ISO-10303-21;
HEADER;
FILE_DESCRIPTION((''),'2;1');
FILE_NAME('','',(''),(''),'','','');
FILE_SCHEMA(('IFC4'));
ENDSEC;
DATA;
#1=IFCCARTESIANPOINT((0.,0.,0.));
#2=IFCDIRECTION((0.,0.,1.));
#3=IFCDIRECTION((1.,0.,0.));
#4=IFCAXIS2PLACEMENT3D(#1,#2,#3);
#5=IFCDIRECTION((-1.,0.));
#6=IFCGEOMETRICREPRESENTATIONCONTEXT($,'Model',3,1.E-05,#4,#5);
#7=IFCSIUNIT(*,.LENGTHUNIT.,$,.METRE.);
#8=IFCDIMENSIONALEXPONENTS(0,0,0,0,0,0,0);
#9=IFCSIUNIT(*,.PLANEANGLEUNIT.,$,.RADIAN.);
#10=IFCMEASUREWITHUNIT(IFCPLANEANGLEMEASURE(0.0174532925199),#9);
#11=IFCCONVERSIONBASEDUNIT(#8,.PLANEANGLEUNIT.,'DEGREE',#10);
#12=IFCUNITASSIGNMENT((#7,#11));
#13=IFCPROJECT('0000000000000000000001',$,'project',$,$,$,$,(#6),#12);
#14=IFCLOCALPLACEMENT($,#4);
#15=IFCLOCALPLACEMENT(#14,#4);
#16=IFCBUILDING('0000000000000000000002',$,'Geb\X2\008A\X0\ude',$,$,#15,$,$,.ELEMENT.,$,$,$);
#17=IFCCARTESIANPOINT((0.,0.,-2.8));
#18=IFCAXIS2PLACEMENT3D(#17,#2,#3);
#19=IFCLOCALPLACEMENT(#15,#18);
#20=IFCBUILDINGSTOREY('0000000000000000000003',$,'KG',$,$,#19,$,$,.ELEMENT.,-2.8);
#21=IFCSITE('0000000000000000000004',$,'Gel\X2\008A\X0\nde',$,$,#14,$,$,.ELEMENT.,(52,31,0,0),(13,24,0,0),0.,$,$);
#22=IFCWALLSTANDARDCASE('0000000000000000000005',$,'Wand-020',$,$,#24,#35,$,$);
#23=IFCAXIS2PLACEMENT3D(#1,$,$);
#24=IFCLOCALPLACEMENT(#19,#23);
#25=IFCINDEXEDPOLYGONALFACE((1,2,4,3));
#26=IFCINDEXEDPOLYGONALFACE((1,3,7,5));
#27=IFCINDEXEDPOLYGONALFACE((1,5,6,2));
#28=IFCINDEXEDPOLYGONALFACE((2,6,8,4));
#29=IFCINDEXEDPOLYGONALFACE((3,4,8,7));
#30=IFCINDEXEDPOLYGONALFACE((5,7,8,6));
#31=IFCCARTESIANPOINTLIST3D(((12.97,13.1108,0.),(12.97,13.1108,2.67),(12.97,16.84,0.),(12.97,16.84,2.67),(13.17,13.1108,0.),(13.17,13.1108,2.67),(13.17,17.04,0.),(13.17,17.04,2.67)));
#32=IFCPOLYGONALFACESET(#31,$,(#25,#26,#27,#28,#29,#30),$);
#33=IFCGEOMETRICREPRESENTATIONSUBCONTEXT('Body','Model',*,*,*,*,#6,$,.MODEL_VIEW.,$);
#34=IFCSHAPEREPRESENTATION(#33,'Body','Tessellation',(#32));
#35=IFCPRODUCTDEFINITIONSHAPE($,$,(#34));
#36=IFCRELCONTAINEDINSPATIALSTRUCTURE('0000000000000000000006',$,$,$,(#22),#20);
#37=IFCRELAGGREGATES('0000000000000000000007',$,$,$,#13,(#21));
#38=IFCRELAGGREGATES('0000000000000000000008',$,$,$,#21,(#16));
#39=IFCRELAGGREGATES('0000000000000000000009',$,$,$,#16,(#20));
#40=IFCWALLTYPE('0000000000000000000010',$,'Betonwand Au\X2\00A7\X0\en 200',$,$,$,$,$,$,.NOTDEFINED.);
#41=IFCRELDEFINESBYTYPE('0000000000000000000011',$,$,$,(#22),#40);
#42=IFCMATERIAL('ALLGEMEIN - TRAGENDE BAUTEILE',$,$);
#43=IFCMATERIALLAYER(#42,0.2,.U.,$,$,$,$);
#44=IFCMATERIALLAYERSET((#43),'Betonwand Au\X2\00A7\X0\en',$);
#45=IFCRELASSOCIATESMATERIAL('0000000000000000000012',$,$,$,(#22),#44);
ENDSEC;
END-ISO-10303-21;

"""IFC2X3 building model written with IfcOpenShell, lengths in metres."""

from ifc_helpers import new_model, entity, si_unit, converted_unit, direction, frame, origin_with_axes, place, context, subcontext, project, spatial, polyline, outline, extrude, material, layer, layer_set, layer_usage, type_object, element, save


model = new_model("IFC2X3")

# Units and contexts
model_context = context("Model", 3, precision=1e-05, world=origin_with_axes(), true_north=direction((-1.0, 0.0)))
body_context = subcontext(model_context, "Body", "Model", "MODEL_VIEW")
ifc_project = project(units=[si_unit("LENGTHUNIT", "METRE"), converted_unit("PLANEANGLEUNIT", "DEGREE", entity("IfcPlaneAngleMeasure", 0.0174532925199), si_unit("PLANEANGLEUNIT", "RADIAN"), dimensions=[0, 0, 0, 0, 0, 0, 0])], contexts=[model_context])

# Site, building, storey
site_placement = place(None, origin_with_axes())
site = spatial("IfcSite", under=ifc_project, at=site_placement, Name="Gel\u008ande", CompositionType="ELEMENT", RefLatitude=(52, 31, 0, 0), RefLongitude=(13, 24, 0, 0), RefElevation=0.0)
building_placement = place(site_placement, origin_with_axes())
building = spatial("IfcBuilding", under=site, at=building_placement, Name="Geb\u008aude", CompositionType="ELEMENT")
storey_placement = place(building_placement, frame((0.0, 0.0, -2.8), z_axis=(0.0, 0.0, 1.0), x_axis=(1.0, 0.0, 0.0)))
storey = spatial("IfcBuildingStorey", under=building, at=storey_placement, Name="KG", CompositionType="ELEMENT", Elevation=-2.8)

# Shared definitions
ifc_material_1 = material(Name="ALLGEMEIN - TRAGENDE BAUTEILE")

# Wall
ifc_layer_1 = layer(ifc_material_1, 0.2, ventilated="UNKNOWN")
ifc_layer_set_1 = layer_set([ifc_layer_1], Name="Betonwand Au§en")
wall_type_1 = type_object("IfcWallType", Name="Betonwand Au§en 200", PredefinedType="NOTDEFINED")
ifc_layer_usage_1 = layer_usage(ifc_layer_set_1, "AXIS2", "NEGATIVE", 0.0)
wall_1_placement = place(storey_placement, frame((12.97, 13.1108, 0.0), z_axis=(0.0, 0.0, 1.0), x_axis=(0.0, 1.0, 0.0)))
element("IfcWallStandardCase", 1, at=wall_1_placement, inside=storey, type_object=wall_type_1, material=ifc_layer_usage_1, Name="Wand-020", context=body_context, shape_type="SweptSolid", body=[
    extrude(outline(polyline([(0.0, -0.2), (3.9292, -0.2), (3.7292, 0.0), (0.0, 0.0), (0.0, -0.2)])), origin_with_axes(), (0.0, 0.0, 1.0), 2.67),
])

save(model, "model.ifc")
